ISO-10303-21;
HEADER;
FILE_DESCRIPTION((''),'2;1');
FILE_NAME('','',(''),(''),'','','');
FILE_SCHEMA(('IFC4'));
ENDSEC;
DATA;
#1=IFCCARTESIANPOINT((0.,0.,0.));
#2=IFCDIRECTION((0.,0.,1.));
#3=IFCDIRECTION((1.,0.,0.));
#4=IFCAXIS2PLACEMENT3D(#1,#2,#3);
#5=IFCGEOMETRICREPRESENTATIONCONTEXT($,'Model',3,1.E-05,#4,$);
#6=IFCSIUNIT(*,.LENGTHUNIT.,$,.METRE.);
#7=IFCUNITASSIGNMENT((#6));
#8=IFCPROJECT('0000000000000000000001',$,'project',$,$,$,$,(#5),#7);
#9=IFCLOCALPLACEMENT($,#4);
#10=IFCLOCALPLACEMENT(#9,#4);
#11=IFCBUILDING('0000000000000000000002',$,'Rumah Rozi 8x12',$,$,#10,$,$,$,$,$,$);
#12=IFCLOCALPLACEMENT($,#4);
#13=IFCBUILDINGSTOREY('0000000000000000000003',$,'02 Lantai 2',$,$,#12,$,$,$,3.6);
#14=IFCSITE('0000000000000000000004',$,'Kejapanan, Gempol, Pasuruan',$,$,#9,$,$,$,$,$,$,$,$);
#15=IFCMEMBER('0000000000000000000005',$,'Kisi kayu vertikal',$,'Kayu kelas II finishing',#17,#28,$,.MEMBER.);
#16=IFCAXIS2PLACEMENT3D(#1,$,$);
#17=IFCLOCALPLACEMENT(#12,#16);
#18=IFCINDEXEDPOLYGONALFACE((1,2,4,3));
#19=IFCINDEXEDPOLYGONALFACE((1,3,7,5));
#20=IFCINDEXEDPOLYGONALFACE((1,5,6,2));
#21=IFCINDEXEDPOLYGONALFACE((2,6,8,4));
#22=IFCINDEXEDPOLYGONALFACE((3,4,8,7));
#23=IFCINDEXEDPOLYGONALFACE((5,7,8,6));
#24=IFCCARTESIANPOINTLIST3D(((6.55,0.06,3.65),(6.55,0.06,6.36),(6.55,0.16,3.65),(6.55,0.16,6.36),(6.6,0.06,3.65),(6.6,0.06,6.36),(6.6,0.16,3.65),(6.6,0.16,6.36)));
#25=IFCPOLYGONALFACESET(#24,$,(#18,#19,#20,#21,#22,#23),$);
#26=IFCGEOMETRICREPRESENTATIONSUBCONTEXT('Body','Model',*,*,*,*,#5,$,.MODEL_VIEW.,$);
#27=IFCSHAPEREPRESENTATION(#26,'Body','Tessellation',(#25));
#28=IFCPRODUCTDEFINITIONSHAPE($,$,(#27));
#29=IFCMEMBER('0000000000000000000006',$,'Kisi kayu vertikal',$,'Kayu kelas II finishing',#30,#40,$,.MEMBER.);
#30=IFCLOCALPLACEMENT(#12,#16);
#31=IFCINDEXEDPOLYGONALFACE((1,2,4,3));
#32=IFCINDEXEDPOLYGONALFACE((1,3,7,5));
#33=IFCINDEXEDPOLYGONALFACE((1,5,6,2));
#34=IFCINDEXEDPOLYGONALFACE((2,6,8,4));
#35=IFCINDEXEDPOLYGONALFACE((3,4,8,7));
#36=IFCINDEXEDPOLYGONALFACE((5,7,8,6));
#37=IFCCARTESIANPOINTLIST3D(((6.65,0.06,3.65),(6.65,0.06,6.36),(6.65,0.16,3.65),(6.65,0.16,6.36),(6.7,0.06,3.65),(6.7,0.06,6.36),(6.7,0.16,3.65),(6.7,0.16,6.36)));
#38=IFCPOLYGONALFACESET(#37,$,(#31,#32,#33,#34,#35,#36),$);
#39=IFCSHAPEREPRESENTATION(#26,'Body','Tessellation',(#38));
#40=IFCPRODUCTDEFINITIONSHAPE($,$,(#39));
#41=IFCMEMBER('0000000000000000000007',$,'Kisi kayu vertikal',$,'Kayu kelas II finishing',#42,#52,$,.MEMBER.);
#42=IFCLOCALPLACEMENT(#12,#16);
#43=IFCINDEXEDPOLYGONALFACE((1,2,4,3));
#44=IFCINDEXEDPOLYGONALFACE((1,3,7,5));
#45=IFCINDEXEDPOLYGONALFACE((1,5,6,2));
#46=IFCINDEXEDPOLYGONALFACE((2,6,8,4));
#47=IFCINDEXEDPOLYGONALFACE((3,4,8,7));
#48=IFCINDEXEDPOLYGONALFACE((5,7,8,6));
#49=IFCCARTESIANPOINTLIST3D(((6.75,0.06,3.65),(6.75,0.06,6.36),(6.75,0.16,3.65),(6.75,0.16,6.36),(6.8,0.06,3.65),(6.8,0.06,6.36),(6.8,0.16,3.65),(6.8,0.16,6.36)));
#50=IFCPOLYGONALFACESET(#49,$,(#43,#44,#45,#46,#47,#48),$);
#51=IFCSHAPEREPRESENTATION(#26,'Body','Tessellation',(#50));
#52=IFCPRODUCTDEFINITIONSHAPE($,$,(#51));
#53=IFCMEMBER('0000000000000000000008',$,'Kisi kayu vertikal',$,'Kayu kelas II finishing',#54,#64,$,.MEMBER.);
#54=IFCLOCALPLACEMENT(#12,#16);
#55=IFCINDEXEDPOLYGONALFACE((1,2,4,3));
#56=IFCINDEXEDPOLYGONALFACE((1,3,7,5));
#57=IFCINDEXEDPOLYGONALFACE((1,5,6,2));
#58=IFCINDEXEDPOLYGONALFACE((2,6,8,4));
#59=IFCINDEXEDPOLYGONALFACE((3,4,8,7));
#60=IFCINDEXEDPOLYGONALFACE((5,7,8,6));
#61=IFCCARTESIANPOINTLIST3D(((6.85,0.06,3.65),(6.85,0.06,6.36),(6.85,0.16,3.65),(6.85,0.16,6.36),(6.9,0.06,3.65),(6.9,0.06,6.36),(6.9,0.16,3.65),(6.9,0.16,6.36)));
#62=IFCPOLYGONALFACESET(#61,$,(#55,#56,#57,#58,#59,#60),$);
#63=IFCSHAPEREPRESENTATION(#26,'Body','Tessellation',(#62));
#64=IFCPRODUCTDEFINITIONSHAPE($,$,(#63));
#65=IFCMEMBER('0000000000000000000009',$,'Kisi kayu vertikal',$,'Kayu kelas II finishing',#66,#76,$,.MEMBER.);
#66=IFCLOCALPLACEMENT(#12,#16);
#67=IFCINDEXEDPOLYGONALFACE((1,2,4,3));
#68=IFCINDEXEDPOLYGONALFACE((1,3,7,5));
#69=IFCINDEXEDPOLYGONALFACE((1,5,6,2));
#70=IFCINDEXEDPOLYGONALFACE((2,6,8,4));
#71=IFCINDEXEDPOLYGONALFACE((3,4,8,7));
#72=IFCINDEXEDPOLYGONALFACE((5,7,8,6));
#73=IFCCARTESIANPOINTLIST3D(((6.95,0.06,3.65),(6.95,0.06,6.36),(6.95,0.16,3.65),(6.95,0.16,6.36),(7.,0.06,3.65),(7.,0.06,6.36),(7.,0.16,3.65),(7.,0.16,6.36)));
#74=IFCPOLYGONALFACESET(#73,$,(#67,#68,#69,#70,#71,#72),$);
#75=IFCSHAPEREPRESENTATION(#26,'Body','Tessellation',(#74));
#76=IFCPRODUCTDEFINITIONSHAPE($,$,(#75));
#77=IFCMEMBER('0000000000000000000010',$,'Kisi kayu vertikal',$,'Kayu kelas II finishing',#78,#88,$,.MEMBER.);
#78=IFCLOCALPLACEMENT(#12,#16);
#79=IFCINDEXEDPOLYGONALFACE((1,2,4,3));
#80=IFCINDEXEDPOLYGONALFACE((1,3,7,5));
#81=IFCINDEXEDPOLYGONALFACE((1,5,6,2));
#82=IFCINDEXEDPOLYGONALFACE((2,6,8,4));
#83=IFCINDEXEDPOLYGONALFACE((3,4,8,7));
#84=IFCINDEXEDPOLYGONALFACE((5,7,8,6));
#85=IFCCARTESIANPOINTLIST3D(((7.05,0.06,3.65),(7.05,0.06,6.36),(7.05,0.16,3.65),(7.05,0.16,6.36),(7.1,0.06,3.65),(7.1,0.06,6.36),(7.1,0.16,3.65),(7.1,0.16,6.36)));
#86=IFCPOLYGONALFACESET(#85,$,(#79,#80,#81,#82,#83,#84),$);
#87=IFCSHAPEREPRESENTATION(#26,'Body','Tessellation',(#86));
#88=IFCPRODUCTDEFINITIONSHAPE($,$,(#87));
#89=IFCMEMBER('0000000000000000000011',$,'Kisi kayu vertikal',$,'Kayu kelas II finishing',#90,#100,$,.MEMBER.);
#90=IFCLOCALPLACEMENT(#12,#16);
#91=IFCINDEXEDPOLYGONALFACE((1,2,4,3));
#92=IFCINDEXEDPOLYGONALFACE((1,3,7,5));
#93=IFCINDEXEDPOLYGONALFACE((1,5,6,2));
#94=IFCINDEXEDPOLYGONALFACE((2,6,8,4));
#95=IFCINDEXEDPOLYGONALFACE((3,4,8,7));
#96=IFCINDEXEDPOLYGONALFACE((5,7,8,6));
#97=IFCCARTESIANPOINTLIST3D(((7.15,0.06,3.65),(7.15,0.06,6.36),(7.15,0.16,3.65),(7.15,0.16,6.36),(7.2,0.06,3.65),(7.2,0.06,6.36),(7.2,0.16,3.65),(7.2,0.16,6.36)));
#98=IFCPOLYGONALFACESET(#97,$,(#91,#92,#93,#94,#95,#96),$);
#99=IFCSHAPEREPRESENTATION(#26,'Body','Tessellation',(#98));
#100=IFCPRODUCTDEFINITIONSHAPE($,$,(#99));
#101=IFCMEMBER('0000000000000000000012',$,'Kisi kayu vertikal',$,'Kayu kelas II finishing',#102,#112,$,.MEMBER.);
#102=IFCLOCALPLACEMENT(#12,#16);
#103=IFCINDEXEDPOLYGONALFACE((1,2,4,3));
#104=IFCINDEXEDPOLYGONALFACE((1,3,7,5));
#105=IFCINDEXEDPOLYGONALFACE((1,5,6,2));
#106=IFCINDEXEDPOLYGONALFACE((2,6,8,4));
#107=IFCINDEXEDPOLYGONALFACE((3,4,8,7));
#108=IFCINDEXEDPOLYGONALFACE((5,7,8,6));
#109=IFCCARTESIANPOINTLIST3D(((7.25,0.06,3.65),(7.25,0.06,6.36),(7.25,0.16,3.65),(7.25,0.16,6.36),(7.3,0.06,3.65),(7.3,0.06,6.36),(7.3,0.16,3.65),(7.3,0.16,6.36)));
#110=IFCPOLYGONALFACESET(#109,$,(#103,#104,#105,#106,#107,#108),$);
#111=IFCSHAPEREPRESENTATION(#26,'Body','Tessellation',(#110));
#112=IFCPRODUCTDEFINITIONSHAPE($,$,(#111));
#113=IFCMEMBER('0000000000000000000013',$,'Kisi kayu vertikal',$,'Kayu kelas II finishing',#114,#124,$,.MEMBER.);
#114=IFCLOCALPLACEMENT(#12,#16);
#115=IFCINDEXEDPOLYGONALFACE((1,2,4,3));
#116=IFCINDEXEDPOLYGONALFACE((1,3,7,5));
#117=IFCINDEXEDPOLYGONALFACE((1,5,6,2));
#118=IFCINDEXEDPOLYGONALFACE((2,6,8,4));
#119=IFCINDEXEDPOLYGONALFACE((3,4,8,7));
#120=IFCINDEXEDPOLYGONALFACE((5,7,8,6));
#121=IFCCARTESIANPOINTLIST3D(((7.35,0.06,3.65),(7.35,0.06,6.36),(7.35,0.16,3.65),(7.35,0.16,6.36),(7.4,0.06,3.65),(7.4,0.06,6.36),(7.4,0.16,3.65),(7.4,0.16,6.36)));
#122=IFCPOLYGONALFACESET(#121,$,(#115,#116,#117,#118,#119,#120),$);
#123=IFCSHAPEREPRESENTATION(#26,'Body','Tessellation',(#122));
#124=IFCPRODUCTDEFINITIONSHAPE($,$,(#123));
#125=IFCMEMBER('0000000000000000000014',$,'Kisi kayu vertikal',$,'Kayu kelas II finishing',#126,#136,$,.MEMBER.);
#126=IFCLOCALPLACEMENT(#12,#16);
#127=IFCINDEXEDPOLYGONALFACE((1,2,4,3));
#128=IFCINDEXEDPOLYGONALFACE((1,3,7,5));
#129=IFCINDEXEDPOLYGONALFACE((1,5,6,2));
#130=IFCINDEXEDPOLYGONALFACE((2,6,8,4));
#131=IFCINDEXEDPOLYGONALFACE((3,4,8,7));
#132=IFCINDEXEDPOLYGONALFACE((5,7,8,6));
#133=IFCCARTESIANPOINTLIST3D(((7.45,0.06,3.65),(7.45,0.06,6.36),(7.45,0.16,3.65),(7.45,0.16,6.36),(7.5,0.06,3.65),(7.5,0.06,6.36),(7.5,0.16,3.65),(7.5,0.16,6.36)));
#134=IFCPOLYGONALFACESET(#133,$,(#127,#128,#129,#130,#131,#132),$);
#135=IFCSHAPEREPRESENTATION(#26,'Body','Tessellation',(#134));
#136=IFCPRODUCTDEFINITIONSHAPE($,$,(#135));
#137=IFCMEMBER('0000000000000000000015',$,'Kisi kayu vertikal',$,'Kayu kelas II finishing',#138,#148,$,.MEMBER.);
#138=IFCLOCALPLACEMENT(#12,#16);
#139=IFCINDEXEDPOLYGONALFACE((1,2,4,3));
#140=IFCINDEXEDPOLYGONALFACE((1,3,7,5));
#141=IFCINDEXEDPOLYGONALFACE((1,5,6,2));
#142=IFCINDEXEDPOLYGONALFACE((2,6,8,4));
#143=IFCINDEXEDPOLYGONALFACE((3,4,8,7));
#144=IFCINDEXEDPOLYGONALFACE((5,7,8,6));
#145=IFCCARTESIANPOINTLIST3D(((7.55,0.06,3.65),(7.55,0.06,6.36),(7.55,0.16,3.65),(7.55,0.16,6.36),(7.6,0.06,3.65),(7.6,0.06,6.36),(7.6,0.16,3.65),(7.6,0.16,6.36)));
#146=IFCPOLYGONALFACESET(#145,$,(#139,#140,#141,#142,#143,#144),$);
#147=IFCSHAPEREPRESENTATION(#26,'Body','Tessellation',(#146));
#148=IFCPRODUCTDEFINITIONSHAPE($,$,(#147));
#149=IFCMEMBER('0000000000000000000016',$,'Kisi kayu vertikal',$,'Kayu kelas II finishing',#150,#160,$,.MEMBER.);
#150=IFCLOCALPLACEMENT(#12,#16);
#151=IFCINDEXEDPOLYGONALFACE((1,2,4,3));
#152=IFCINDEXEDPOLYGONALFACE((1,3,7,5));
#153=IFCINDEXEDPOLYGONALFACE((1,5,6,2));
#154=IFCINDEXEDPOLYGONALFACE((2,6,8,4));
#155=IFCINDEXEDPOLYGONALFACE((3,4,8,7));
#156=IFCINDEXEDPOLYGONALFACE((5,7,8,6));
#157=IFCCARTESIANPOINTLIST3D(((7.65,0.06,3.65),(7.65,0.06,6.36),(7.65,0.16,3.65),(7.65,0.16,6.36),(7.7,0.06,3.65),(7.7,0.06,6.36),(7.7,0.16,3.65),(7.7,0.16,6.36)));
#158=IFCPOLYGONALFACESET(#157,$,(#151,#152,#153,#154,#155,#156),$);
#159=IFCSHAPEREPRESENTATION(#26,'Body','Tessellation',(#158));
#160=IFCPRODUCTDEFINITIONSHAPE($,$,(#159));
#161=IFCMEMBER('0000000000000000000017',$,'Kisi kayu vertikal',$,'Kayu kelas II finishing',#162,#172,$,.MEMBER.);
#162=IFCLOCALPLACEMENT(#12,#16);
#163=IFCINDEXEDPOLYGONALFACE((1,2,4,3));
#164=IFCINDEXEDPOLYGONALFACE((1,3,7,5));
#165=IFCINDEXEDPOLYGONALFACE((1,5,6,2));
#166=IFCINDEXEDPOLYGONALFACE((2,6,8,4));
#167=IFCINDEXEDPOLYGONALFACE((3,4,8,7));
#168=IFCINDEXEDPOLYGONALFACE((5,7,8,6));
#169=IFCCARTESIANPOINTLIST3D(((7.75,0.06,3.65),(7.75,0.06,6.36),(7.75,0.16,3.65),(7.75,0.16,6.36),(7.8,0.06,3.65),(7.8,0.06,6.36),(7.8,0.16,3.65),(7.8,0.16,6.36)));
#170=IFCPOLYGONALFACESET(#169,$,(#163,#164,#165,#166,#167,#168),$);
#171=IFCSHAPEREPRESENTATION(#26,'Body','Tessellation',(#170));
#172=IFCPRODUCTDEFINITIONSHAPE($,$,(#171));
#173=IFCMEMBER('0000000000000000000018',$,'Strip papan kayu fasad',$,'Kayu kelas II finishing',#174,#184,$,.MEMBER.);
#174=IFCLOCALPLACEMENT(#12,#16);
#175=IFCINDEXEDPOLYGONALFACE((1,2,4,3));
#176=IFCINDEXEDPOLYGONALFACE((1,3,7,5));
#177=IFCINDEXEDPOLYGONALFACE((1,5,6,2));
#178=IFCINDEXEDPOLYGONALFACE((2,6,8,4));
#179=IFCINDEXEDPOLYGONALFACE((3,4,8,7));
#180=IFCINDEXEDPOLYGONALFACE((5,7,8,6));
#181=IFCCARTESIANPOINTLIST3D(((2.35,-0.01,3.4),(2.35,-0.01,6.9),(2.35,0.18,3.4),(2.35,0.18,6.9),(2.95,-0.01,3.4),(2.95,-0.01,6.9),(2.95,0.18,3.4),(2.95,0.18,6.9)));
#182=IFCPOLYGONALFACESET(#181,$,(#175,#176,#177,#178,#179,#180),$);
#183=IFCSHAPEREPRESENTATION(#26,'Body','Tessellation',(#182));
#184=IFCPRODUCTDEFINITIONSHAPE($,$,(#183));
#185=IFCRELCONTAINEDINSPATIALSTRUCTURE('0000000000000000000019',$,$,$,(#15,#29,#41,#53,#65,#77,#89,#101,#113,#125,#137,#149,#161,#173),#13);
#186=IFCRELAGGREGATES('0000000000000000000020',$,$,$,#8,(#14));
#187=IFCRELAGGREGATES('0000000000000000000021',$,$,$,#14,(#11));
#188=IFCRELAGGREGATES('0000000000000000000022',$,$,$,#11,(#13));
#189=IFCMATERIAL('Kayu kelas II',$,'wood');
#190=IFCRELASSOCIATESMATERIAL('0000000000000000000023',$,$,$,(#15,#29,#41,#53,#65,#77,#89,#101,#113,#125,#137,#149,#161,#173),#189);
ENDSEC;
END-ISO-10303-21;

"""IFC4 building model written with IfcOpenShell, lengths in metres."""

from ifc_helpers import new_model, si_unit, frame, origin_with_axes, place, context, subcontext, project, spatial, line, indexed_curve, outline, extrude, material, element, save


model = new_model("IFC4")

# Units and contexts
model_context = context("Model", 3, precision=1e-05, world=origin_with_axes())
body_context = subcontext(model_context, "Body", "Model", "MODEL_VIEW")
ifc_project = project(units=[si_unit("LENGTHUNIT", "METRE")], contexts=[model_context])

# Site, building, storey
site_placement = place(None, origin_with_axes())
site = spatial("IfcSite", under=ifc_project, at=site_placement, Name="Kejapanan, Gempol, Pasuruan")
building_placement = place(site_placement, origin_with_axes())
building = spatial("IfcBuilding", under=site, at=building_placement, Name="Rumah Rozi 8x12")
storey_placement = place(None, origin_with_axes())
storey = spatial("IfcBuildingStorey", under=building, at=storey_placement, Name="02 Lantai 2", Elevation=3.6)

# Members
ifc_material_1 = material(Name="Kayu kelas II", Category="wood")
member_1_placement = place(storey_placement, origin_with_axes())
element("IfcMember", 1, at=member_1_placement, inside=storey, material=ifc_material_1, Name="Kisi kayu vertikal", ObjectType="Kayu kelas II finishing", PredefinedType="MEMBER", context=body_context, shape_type="SweptSolid", body=[
    extrude(outline(indexed_curve([(6.55, 0.06), (6.6, 0.06), (6.6, 0.16), (6.55, 0.16)], segments=[line(1, 2, 3, 4, 1)])), frame((0.0, 0.0, 3.65), z_axis=(0.0, 0.0, 1.0), x_axis=(1.0, 0.0, 0.0)), (0.0, 0.0, 1.0), 2.71),
])
member_2_placement = place(storey_placement, origin_with_axes())
element("IfcMember", 2, at=member_2_placement, inside=storey, material=ifc_material_1, Name="Kisi kayu vertikal", ObjectType="Kayu kelas II finishing", PredefinedType="MEMBER", context=body_context, shape_type="SweptSolid", body=[
    extrude(outline(indexed_curve([(6.65, 0.06), (6.7, 0.06), (6.7, 0.16), (6.65, 0.16)], segments=[line(1, 2, 3, 4, 1)])), frame((0.0, 0.0, 3.65), z_axis=(0.0, 0.0, 1.0), x_axis=(1.0, 0.0, 0.0)), (0.0, 0.0, 1.0), 2.71),
])
member_3_placement = place(storey_placement, origin_with_axes())
element("IfcMember", 3, at=member_3_placement, inside=storey, material=ifc_material_1, Name="Kisi kayu vertikal", ObjectType="Kayu kelas II finishing", PredefinedType="MEMBER", context=body_context, shape_type="SweptSolid", body=[
    extrude(outline(indexed_curve([(6.75, 0.06), (6.8, 0.06), (6.8, 0.16), (6.75, 0.16)], segments=[line(1, 2, 3, 4, 1)])), frame((0.0, 0.0, 3.65), z_axis=(0.0, 0.0, 1.0), x_axis=(1.0, 0.0, 0.0)), (0.0, 0.0, 1.0), 2.71),
])
member_4_placement = place(storey_placement, origin_with_axes())
element("IfcMember", 4, at=member_4_placement, inside=storey, material=ifc_material_1, Name="Kisi kayu vertikal", ObjectType="Kayu kelas II finishing", PredefinedType="MEMBER", context=body_context, shape_type="SweptSolid", body=[
    extrude(outline(indexed_curve([(6.85, 0.06), (6.9, 0.06), (6.9, 0.16), (6.85, 0.16)], segments=[line(1, 2, 3, 4, 1)])), frame((0.0, 0.0, 3.65), z_axis=(0.0, 0.0, 1.0), x_axis=(1.0, 0.0, 0.0)), (0.0, 0.0, 1.0), 2.71),
])
member_5_placement = place(storey_placement, origin_with_axes())
element("IfcMember", 5, at=member_5_placement, inside=storey, material=ifc_material_1, Name="Kisi kayu vertikal", ObjectType="Kayu kelas II finishing", PredefinedType="MEMBER", context=body_context, shape_type="SweptSolid", body=[
    extrude(outline(indexed_curve([(6.95, 0.06), (7.0, 0.06), (7.0, 0.16), (6.95, 0.16)], segments=[line(1, 2, 3, 4, 1)])), frame((0.0, 0.0, 3.65), z_axis=(0.0, 0.0, 1.0), x_axis=(1.0, 0.0, 0.0)), (0.0, 0.0, 1.0), 2.71),
])
member_6_placement = place(storey_placement, origin_with_axes())
element("IfcMember", 6, at=member_6_placement, inside=storey, material=ifc_material_1, Name="Kisi kayu vertikal", ObjectType="Kayu kelas II finishing", PredefinedType="MEMBER", context=body_context, shape_type="SweptSolid", body=[
    extrude(outline(indexed_curve([(7.05, 0.06), (7.1, 0.06), (7.1, 0.16), (7.05, 0.16)], segments=[line(1, 2, 3, 4, 1)])), frame((0.0, 0.0, 3.65), z_axis=(0.0, 0.0, 1.0), x_axis=(1.0, 0.0, 0.0)), (0.0, 0.0, 1.0), 2.71),
])
member_7_placement = place(storey_placement, origin_with_axes())
element("IfcMember", 7, at=member_7_placement, inside=storey, material=ifc_material_1, Name="Kisi kayu vertikal", ObjectType="Kayu kelas II finishing", PredefinedType="MEMBER", context=body_context, shape_type="SweptSolid", body=[
    extrude(outline(indexed_curve([(7.15, 0.06), (7.2, 0.06), (7.2, 0.16), (7.15, 0.16)], segments=[line(1, 2, 3, 4, 1)])), frame((0.0, 0.0, 3.65), z_axis=(0.0, 0.0, 1.0), x_axis=(1.0, 0.0, 0.0)), (0.0, 0.0, 1.0), 2.71),
])
member_8_placement = place(storey_placement, origin_with_axes())
element("IfcMember", 8, at=member_8_placement, inside=storey, material=ifc_material_1, Name="Kisi kayu vertikal", ObjectType="Kayu kelas II finishing", PredefinedType="MEMBER", context=body_context, shape_type="SweptSolid", body=[
    extrude(outline(indexed_curve([(7.25, 0.06), (7.3, 0.06), (7.3, 0.16), (7.25, 0.16)], segments=[line(1, 2, 3, 4, 1)])), frame((0.0, 0.0, 3.65), z_axis=(0.0, 0.0, 1.0), x_axis=(1.0, 0.0, 0.0)), (0.0, 0.0, 1.0), 2.71),
])
member_9_placement = place(storey_placement, origin_with_axes())
element("IfcMember", 9, at=member_9_placement, inside=storey, material=ifc_material_1, Name="Kisi kayu vertikal", ObjectType="Kayu kelas II finishing", PredefinedType="MEMBER", context=body_context, shape_type="SweptSolid", body=[
    extrude(outline(indexed_curve([(7.35, 0.06), (7.4, 0.06), (7.4, 0.16), (7.35, 0.16)], segments=[line(1, 2, 3, 4, 1)])), frame((0.0, 0.0, 3.65), z_axis=(0.0, 0.0, 1.0), x_axis=(1.0, 0.0, 0.0)), (0.0, 0.0, 1.0), 2.71),
])
member_10_placement = place(storey_placement, origin_with_axes())
element("IfcMember", 10, at=member_10_placement, inside=storey, material=ifc_material_1, Name="Kisi kayu vertikal", ObjectType="Kayu kelas II finishing", PredefinedType="MEMBER", context=body_context, shape_type="SweptSolid", body=[
    extrude(outline(indexed_curve([(7.45, 0.06), (7.5, 0.06), (7.5, 0.16), (7.45, 0.16)], segments=[line(1, 2, 3, 4, 1)])), frame((0.0, 0.0, 3.65), z_axis=(0.0, 0.0, 1.0), x_axis=(1.0, 0.0, 0.0)), (0.0, 0.0, 1.0), 2.71),
])
member_11_placement = place(storey_placement, origin_with_axes())
element("IfcMember", 11, at=member_11_placement, inside=storey, material=ifc_material_1, Name="Kisi kayu vertikal", ObjectType="Kayu kelas II finishing", PredefinedType="MEMBER", context=body_context, shape_type="SweptSolid", body=[
    extrude(outline(indexed_curve([(7.55, 0.06), (7.6, 0.06), (7.6, 0.16), (7.55, 0.16)], segments=[line(1, 2, 3, 4, 1)])), frame((0.0, 0.0, 3.65), z_axis=(0.0, 0.0, 1.0), x_axis=(1.0, 0.0, 0.0)), (0.0, 0.0, 1.0), 2.71),
])
member_12_placement = place(storey_placement, origin_with_axes())
element("IfcMember", 12, at=member_12_placement, inside=storey, material=ifc_material_1, Name="Kisi kayu vertikal", ObjectType="Kayu kelas II finishing", PredefinedType="MEMBER", context=body_context, shape_type="SweptSolid", body=[
    extrude(outline(indexed_curve([(7.65, 0.06), (7.7, 0.06), (7.7, 0.16), (7.65, 0.16)], segments=[line(1, 2, 3, 4, 1)])), frame((0.0, 0.0, 3.65), z_axis=(0.0, 0.0, 1.0), x_axis=(1.0, 0.0, 0.0)), (0.0, 0.0, 1.0), 2.71),
])
member_13_placement = place(storey_placement, origin_with_axes())
element("IfcMember", 13, at=member_13_placement, inside=storey, material=ifc_material_1, Name="Kisi kayu vertikal", ObjectType="Kayu kelas II finishing", PredefinedType="MEMBER", context=body_context, shape_type="SweptSolid", body=[
    extrude(outline(indexed_curve([(7.75, 0.06), (7.8, 0.06), (7.8, 0.16), (7.75, 0.16)], segments=[line(1, 2, 3, 4, 1)])), frame((0.0, 0.0, 3.65), z_axis=(0.0, 0.0, 1.0), x_axis=(1.0, 0.0, 0.0)), (0.0, 0.0, 1.0), 2.71),
])
member_14_placement = place(storey_placement, origin_with_axes())
element("IfcMember", 14, at=member_14_placement, inside=storey, material=ifc_material_1, Name="Strip papan kayu fasad", ObjectType="Kayu kelas II finishing", PredefinedType="MEMBER", context=body_context, shape_type="SweptSolid", body=[
    extrude(outline(indexed_curve([(2.35, -0.01), (2.95, -0.01), (2.95, 0.18), (2.35, 0.18)], segments=[line(1, 2, 3, 4, 1)])), frame((0.0, 0.0, 3.4), z_axis=(0.0, 0.0, 1.0), x_axis=(1.0, 0.0, 0.0)), (0.0, 0.0, 1.0), 3.5),
])

save(model, "model.ifc")
